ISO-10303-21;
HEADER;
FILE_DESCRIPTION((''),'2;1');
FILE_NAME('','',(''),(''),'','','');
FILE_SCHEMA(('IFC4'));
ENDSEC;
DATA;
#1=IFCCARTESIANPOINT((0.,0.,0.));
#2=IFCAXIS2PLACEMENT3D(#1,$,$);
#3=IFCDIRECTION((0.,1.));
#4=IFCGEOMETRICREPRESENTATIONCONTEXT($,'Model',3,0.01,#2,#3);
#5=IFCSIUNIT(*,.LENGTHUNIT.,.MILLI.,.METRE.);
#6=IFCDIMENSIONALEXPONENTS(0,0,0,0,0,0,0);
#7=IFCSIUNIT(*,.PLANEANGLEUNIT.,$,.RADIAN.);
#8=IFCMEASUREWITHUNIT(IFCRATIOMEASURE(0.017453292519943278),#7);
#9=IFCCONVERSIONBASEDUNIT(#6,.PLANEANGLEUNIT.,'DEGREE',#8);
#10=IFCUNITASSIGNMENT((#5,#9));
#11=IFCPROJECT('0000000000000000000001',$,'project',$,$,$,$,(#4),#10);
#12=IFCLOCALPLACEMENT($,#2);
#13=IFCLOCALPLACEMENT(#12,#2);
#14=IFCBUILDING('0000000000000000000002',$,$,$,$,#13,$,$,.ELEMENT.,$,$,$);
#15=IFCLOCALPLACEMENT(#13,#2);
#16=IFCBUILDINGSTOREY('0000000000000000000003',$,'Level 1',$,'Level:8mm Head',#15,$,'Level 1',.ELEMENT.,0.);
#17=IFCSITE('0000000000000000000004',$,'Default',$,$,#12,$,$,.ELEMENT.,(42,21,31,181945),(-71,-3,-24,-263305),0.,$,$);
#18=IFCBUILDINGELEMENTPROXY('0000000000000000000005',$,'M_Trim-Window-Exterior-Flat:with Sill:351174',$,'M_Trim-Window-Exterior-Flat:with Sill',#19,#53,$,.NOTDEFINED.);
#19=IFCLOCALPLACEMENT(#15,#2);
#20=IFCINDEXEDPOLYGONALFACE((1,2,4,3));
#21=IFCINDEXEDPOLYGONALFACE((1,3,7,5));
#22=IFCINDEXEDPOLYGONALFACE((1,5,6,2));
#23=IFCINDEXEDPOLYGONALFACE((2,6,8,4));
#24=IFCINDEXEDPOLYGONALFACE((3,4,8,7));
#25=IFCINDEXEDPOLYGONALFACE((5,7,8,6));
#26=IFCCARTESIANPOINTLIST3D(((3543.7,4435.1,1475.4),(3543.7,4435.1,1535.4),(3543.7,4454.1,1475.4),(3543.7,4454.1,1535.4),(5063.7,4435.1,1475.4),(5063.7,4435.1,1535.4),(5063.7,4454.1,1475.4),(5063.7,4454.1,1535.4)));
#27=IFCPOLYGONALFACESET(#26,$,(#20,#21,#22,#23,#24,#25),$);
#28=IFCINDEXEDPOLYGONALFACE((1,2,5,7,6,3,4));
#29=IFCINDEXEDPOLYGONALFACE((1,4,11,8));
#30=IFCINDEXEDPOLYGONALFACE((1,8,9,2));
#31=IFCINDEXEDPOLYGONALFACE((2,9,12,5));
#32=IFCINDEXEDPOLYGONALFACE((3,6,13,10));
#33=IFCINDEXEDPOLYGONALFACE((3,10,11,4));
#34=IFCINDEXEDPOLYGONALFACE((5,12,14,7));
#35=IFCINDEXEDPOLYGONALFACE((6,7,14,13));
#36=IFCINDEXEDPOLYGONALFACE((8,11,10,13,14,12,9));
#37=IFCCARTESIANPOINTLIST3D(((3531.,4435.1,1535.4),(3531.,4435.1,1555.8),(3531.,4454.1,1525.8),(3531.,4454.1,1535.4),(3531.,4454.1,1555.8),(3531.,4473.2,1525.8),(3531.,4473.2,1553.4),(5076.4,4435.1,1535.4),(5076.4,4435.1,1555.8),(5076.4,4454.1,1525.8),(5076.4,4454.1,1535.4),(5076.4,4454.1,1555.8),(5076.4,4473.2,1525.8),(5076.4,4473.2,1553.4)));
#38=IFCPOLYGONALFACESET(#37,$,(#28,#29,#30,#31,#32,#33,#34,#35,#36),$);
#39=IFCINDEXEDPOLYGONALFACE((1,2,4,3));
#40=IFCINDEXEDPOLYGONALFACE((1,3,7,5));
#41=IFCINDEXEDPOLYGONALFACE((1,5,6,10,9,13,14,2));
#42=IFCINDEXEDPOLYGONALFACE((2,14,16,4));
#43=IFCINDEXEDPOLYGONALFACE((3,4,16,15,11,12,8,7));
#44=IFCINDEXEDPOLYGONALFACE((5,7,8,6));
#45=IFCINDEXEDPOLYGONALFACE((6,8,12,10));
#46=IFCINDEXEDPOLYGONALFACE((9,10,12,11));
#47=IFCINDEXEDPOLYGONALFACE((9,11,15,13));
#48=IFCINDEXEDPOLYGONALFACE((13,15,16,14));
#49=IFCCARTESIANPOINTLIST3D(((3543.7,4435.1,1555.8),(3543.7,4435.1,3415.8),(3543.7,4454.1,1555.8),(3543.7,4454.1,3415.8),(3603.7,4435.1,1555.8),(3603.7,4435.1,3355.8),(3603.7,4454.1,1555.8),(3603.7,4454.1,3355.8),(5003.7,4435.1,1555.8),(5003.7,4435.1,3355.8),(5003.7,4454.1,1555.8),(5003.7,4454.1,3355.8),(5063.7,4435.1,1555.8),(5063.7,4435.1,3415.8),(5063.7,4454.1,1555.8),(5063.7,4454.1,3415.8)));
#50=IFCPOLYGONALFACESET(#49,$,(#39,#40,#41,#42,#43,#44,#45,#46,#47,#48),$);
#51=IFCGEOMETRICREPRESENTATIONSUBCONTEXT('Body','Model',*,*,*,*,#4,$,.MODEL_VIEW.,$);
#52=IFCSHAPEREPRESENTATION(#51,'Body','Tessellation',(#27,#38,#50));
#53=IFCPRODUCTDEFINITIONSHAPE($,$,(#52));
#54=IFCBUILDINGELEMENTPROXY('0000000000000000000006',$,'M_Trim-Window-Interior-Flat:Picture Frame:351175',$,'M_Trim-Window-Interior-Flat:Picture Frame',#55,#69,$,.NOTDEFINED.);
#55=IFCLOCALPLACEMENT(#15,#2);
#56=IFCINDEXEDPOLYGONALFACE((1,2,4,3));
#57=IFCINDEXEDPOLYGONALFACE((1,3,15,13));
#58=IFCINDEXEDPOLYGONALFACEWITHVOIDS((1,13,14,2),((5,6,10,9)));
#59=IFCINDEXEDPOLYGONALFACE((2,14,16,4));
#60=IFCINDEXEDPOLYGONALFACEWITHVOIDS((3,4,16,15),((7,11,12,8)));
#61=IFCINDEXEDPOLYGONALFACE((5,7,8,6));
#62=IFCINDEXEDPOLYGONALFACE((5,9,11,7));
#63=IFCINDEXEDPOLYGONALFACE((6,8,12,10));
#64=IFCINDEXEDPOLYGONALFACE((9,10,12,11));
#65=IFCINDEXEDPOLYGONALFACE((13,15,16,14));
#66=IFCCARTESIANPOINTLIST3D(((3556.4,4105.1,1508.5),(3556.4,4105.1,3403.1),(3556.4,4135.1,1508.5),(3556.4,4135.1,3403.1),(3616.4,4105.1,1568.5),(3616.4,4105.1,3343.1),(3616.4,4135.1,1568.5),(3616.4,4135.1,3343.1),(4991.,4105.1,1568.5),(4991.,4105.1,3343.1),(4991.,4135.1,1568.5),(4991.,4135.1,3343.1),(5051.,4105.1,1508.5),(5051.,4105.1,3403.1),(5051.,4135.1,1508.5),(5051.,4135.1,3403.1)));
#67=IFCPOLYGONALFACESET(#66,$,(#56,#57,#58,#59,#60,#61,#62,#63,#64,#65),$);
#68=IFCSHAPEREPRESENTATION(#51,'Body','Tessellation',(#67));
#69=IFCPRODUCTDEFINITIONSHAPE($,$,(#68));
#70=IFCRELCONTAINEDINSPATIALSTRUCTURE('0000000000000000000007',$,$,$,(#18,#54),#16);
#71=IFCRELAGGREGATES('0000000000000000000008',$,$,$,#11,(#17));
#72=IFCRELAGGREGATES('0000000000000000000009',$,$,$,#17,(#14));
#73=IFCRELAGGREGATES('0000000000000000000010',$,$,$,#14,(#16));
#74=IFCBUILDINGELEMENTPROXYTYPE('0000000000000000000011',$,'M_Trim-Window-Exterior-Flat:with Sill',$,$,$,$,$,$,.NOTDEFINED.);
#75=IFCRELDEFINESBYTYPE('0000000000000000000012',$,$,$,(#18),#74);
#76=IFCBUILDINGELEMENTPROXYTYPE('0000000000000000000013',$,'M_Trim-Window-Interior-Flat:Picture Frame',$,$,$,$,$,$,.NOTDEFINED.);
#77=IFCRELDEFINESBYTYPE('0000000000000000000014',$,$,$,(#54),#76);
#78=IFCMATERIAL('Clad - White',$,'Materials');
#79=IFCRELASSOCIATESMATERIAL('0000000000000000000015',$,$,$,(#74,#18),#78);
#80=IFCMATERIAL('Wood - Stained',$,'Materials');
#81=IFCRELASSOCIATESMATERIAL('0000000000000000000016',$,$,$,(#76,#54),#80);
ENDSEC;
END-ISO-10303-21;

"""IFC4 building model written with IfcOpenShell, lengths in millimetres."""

from ifc_helpers import new_model, entity, si_unit, converted_unit, direction, frame, origin, place, context, subcontext, project, spatial, indexed_curve, outline, extrude, source, transform, mapped, material, type_object, type_shapes, element, save


model = new_model("IFC4")

# Units and contexts
model_context = context("Model", 3, precision=0.01, world=origin(), true_north=direction((0.0, 1.0)))
body_context = subcontext(model_context, "Body", "Model", "MODEL_VIEW")
ifc_project = project(units=[si_unit("LENGTHUNIT", "METRE", prefix="MILLI"), converted_unit("PLANEANGLEUNIT", "DEGREE", entity("IfcRatioMeasure", 0.017453292519943278), si_unit("PLANEANGLEUNIT", "RADIAN"), dimensions=[0, 0, 0, 0, 0, 0, 0])], contexts=[model_context])

# Site, building, storey
site_placement = place(None, origin())
site = spatial("IfcSite", under=ifc_project, at=site_placement, Name="Default", CompositionType="ELEMENT", RefLatitude=(42, 21, 31, 181945), RefLongitude=(-71, -3, -24, -263305), RefElevation=0.0)
building_placement = place(site_placement, origin())
building = spatial("IfcBuilding", under=site, at=building_placement, CompositionType="ELEMENT")
storey_placement = place(building_placement, origin())
storey = spatial("IfcBuildingStorey", under=building, at=storey_placement, Name="Level 1", ObjectType="Level:8mm Head", LongName="Level 1", CompositionType="ELEMENT", Elevation=0.0)

# Building element proxies
ifc_material_1 = material(Name="Clad - White", Category="Materials")
ifc_material_2 = material(Name="Wood - Stained", Category="Materials")
building_element_proxy_type_1 = type_object("IfcBuildingElementProxyType", Name="M_Trim-Window-Exterior-Flat:with Sill", PredefinedType="NOTDEFINED", material=ifc_material_1)
shared_shape_1 = source(origin(), body_context, "Body", "SweptSolid", [
    extrude(outline(indexed_curve([(-760.0, -30.0), (760.0, -30.0), (760.0, 30.0), (-760.0, 30.0), (-760.0, -30.0)], self_intersect=False)), frame((0.0, -1850.4, 0.0), z_axis=(0.0, 0.0, 1.0), x_axis=(-1.0, 0.0, 0.0)), (0.0, 0.0, 1.0), 19.0),
    extrude(outline(indexed_curve([(-19.0, -15.2), (0.0, -15.2), (0.0, -5.7), (19.0, -5.7), (19.0, 14.8), (0.0, 14.8), (-19.0, 12.3), (-19.0, -15.2)], self_intersect=False)), frame((-772.7, -1814.8, 19.0), z_axis=(1.0, 0.0, 0.0), x_axis=(0.0, 0.0, -1.0)), (0.0, 0.0, 1.0), 1545.4),
    extrude(outline(indexed_curve([(-945.0, -760.0), (915.0, -760.0), (915.0, -700.0), (-885.0, -700.0), (-885.0, 700.0), (915.0, 700.0), (915.0, 760.0), (-945.0, 760.0), (-945.0, -760.0)], self_intersect=False)), frame((0.0, -885.0, 0.0), z_axis=(0.0, 0.0, 1.0), x_axis=(0.0, -1.0, 0.0)), (0.0, 0.0, 1.0), 19.0),
])
type_shapes(building_element_proxy_type_1, [shared_shape_1])
proxy_1_placement = place(storey_placement, frame((4303.7, 4435.1, 3355.8), z_axis=(0.0, 1.0, 0.0), x_axis=(-1.0, 0.0, 0.0)))
element("IfcBuildingElementProxy", 1, at=proxy_1_placement, inside=storey, type_object=building_element_proxy_type_1, material=ifc_material_1, Name="M_Trim-Window-Exterior-Flat:with Sill:351174", ObjectType="M_Trim-Window-Exterior-Flat:with Sill", PredefinedType="NOTDEFINED", context=body_context, shape_type="MappedRepresentation", body=[
    mapped(shared_shape_1, transform((0.0, 0.0, 0.0), scale=1.0)),
])
building_element_proxy_type_2 = type_object("IfcBuildingElementProxyType", Name="M_Trim-Window-Interior-Flat:Picture Frame", PredefinedType="NOTDEFINED", material=ifc_material_2)
shared_shape_2 = source(origin(), body_context, "Body", "SweptSolid", [
    extrude(outline(indexed_curve([(-747.3, -947.3), (747.3, -947.3), (747.3, 947.3), (-747.3, 947.3), (-747.3, -947.3)], self_intersect=False), holes=[indexed_curve([(-687.3, -887.3), (-687.3, 887.3), (687.3, 887.3), (687.3, -887.3), (-687.3, -887.3)], self_intersect=False)]), frame((0.0, -900.0, 0.0), z_axis=(0.0, 0.0, 1.0), x_axis=(-1.0, 0.0, 0.0)), (0.0, 0.0, 1.0), 30.0),
])
type_shapes(building_element_proxy_type_2, [shared_shape_2])
proxy_2_placement = place(storey_placement, frame((4303.7, 4135.1, 3355.8), z_axis=(0.0, -1.0, 0.0), x_axis=(1.0, 0.0, 0.0)))
element("IfcBuildingElementProxy", 2, at=proxy_2_placement, inside=storey, type_object=building_element_proxy_type_2, material=ifc_material_2, Name="M_Trim-Window-Interior-Flat:Picture Frame:351175", ObjectType="M_Trim-Window-Interior-Flat:Picture Frame", PredefinedType="NOTDEFINED", context=body_context, shape_type="MappedRepresentation", body=[
    mapped(shared_shape_2, transform((0.0, 0.0, 0.0), scale=1.0)),
])

save(model, "model.ifc")
